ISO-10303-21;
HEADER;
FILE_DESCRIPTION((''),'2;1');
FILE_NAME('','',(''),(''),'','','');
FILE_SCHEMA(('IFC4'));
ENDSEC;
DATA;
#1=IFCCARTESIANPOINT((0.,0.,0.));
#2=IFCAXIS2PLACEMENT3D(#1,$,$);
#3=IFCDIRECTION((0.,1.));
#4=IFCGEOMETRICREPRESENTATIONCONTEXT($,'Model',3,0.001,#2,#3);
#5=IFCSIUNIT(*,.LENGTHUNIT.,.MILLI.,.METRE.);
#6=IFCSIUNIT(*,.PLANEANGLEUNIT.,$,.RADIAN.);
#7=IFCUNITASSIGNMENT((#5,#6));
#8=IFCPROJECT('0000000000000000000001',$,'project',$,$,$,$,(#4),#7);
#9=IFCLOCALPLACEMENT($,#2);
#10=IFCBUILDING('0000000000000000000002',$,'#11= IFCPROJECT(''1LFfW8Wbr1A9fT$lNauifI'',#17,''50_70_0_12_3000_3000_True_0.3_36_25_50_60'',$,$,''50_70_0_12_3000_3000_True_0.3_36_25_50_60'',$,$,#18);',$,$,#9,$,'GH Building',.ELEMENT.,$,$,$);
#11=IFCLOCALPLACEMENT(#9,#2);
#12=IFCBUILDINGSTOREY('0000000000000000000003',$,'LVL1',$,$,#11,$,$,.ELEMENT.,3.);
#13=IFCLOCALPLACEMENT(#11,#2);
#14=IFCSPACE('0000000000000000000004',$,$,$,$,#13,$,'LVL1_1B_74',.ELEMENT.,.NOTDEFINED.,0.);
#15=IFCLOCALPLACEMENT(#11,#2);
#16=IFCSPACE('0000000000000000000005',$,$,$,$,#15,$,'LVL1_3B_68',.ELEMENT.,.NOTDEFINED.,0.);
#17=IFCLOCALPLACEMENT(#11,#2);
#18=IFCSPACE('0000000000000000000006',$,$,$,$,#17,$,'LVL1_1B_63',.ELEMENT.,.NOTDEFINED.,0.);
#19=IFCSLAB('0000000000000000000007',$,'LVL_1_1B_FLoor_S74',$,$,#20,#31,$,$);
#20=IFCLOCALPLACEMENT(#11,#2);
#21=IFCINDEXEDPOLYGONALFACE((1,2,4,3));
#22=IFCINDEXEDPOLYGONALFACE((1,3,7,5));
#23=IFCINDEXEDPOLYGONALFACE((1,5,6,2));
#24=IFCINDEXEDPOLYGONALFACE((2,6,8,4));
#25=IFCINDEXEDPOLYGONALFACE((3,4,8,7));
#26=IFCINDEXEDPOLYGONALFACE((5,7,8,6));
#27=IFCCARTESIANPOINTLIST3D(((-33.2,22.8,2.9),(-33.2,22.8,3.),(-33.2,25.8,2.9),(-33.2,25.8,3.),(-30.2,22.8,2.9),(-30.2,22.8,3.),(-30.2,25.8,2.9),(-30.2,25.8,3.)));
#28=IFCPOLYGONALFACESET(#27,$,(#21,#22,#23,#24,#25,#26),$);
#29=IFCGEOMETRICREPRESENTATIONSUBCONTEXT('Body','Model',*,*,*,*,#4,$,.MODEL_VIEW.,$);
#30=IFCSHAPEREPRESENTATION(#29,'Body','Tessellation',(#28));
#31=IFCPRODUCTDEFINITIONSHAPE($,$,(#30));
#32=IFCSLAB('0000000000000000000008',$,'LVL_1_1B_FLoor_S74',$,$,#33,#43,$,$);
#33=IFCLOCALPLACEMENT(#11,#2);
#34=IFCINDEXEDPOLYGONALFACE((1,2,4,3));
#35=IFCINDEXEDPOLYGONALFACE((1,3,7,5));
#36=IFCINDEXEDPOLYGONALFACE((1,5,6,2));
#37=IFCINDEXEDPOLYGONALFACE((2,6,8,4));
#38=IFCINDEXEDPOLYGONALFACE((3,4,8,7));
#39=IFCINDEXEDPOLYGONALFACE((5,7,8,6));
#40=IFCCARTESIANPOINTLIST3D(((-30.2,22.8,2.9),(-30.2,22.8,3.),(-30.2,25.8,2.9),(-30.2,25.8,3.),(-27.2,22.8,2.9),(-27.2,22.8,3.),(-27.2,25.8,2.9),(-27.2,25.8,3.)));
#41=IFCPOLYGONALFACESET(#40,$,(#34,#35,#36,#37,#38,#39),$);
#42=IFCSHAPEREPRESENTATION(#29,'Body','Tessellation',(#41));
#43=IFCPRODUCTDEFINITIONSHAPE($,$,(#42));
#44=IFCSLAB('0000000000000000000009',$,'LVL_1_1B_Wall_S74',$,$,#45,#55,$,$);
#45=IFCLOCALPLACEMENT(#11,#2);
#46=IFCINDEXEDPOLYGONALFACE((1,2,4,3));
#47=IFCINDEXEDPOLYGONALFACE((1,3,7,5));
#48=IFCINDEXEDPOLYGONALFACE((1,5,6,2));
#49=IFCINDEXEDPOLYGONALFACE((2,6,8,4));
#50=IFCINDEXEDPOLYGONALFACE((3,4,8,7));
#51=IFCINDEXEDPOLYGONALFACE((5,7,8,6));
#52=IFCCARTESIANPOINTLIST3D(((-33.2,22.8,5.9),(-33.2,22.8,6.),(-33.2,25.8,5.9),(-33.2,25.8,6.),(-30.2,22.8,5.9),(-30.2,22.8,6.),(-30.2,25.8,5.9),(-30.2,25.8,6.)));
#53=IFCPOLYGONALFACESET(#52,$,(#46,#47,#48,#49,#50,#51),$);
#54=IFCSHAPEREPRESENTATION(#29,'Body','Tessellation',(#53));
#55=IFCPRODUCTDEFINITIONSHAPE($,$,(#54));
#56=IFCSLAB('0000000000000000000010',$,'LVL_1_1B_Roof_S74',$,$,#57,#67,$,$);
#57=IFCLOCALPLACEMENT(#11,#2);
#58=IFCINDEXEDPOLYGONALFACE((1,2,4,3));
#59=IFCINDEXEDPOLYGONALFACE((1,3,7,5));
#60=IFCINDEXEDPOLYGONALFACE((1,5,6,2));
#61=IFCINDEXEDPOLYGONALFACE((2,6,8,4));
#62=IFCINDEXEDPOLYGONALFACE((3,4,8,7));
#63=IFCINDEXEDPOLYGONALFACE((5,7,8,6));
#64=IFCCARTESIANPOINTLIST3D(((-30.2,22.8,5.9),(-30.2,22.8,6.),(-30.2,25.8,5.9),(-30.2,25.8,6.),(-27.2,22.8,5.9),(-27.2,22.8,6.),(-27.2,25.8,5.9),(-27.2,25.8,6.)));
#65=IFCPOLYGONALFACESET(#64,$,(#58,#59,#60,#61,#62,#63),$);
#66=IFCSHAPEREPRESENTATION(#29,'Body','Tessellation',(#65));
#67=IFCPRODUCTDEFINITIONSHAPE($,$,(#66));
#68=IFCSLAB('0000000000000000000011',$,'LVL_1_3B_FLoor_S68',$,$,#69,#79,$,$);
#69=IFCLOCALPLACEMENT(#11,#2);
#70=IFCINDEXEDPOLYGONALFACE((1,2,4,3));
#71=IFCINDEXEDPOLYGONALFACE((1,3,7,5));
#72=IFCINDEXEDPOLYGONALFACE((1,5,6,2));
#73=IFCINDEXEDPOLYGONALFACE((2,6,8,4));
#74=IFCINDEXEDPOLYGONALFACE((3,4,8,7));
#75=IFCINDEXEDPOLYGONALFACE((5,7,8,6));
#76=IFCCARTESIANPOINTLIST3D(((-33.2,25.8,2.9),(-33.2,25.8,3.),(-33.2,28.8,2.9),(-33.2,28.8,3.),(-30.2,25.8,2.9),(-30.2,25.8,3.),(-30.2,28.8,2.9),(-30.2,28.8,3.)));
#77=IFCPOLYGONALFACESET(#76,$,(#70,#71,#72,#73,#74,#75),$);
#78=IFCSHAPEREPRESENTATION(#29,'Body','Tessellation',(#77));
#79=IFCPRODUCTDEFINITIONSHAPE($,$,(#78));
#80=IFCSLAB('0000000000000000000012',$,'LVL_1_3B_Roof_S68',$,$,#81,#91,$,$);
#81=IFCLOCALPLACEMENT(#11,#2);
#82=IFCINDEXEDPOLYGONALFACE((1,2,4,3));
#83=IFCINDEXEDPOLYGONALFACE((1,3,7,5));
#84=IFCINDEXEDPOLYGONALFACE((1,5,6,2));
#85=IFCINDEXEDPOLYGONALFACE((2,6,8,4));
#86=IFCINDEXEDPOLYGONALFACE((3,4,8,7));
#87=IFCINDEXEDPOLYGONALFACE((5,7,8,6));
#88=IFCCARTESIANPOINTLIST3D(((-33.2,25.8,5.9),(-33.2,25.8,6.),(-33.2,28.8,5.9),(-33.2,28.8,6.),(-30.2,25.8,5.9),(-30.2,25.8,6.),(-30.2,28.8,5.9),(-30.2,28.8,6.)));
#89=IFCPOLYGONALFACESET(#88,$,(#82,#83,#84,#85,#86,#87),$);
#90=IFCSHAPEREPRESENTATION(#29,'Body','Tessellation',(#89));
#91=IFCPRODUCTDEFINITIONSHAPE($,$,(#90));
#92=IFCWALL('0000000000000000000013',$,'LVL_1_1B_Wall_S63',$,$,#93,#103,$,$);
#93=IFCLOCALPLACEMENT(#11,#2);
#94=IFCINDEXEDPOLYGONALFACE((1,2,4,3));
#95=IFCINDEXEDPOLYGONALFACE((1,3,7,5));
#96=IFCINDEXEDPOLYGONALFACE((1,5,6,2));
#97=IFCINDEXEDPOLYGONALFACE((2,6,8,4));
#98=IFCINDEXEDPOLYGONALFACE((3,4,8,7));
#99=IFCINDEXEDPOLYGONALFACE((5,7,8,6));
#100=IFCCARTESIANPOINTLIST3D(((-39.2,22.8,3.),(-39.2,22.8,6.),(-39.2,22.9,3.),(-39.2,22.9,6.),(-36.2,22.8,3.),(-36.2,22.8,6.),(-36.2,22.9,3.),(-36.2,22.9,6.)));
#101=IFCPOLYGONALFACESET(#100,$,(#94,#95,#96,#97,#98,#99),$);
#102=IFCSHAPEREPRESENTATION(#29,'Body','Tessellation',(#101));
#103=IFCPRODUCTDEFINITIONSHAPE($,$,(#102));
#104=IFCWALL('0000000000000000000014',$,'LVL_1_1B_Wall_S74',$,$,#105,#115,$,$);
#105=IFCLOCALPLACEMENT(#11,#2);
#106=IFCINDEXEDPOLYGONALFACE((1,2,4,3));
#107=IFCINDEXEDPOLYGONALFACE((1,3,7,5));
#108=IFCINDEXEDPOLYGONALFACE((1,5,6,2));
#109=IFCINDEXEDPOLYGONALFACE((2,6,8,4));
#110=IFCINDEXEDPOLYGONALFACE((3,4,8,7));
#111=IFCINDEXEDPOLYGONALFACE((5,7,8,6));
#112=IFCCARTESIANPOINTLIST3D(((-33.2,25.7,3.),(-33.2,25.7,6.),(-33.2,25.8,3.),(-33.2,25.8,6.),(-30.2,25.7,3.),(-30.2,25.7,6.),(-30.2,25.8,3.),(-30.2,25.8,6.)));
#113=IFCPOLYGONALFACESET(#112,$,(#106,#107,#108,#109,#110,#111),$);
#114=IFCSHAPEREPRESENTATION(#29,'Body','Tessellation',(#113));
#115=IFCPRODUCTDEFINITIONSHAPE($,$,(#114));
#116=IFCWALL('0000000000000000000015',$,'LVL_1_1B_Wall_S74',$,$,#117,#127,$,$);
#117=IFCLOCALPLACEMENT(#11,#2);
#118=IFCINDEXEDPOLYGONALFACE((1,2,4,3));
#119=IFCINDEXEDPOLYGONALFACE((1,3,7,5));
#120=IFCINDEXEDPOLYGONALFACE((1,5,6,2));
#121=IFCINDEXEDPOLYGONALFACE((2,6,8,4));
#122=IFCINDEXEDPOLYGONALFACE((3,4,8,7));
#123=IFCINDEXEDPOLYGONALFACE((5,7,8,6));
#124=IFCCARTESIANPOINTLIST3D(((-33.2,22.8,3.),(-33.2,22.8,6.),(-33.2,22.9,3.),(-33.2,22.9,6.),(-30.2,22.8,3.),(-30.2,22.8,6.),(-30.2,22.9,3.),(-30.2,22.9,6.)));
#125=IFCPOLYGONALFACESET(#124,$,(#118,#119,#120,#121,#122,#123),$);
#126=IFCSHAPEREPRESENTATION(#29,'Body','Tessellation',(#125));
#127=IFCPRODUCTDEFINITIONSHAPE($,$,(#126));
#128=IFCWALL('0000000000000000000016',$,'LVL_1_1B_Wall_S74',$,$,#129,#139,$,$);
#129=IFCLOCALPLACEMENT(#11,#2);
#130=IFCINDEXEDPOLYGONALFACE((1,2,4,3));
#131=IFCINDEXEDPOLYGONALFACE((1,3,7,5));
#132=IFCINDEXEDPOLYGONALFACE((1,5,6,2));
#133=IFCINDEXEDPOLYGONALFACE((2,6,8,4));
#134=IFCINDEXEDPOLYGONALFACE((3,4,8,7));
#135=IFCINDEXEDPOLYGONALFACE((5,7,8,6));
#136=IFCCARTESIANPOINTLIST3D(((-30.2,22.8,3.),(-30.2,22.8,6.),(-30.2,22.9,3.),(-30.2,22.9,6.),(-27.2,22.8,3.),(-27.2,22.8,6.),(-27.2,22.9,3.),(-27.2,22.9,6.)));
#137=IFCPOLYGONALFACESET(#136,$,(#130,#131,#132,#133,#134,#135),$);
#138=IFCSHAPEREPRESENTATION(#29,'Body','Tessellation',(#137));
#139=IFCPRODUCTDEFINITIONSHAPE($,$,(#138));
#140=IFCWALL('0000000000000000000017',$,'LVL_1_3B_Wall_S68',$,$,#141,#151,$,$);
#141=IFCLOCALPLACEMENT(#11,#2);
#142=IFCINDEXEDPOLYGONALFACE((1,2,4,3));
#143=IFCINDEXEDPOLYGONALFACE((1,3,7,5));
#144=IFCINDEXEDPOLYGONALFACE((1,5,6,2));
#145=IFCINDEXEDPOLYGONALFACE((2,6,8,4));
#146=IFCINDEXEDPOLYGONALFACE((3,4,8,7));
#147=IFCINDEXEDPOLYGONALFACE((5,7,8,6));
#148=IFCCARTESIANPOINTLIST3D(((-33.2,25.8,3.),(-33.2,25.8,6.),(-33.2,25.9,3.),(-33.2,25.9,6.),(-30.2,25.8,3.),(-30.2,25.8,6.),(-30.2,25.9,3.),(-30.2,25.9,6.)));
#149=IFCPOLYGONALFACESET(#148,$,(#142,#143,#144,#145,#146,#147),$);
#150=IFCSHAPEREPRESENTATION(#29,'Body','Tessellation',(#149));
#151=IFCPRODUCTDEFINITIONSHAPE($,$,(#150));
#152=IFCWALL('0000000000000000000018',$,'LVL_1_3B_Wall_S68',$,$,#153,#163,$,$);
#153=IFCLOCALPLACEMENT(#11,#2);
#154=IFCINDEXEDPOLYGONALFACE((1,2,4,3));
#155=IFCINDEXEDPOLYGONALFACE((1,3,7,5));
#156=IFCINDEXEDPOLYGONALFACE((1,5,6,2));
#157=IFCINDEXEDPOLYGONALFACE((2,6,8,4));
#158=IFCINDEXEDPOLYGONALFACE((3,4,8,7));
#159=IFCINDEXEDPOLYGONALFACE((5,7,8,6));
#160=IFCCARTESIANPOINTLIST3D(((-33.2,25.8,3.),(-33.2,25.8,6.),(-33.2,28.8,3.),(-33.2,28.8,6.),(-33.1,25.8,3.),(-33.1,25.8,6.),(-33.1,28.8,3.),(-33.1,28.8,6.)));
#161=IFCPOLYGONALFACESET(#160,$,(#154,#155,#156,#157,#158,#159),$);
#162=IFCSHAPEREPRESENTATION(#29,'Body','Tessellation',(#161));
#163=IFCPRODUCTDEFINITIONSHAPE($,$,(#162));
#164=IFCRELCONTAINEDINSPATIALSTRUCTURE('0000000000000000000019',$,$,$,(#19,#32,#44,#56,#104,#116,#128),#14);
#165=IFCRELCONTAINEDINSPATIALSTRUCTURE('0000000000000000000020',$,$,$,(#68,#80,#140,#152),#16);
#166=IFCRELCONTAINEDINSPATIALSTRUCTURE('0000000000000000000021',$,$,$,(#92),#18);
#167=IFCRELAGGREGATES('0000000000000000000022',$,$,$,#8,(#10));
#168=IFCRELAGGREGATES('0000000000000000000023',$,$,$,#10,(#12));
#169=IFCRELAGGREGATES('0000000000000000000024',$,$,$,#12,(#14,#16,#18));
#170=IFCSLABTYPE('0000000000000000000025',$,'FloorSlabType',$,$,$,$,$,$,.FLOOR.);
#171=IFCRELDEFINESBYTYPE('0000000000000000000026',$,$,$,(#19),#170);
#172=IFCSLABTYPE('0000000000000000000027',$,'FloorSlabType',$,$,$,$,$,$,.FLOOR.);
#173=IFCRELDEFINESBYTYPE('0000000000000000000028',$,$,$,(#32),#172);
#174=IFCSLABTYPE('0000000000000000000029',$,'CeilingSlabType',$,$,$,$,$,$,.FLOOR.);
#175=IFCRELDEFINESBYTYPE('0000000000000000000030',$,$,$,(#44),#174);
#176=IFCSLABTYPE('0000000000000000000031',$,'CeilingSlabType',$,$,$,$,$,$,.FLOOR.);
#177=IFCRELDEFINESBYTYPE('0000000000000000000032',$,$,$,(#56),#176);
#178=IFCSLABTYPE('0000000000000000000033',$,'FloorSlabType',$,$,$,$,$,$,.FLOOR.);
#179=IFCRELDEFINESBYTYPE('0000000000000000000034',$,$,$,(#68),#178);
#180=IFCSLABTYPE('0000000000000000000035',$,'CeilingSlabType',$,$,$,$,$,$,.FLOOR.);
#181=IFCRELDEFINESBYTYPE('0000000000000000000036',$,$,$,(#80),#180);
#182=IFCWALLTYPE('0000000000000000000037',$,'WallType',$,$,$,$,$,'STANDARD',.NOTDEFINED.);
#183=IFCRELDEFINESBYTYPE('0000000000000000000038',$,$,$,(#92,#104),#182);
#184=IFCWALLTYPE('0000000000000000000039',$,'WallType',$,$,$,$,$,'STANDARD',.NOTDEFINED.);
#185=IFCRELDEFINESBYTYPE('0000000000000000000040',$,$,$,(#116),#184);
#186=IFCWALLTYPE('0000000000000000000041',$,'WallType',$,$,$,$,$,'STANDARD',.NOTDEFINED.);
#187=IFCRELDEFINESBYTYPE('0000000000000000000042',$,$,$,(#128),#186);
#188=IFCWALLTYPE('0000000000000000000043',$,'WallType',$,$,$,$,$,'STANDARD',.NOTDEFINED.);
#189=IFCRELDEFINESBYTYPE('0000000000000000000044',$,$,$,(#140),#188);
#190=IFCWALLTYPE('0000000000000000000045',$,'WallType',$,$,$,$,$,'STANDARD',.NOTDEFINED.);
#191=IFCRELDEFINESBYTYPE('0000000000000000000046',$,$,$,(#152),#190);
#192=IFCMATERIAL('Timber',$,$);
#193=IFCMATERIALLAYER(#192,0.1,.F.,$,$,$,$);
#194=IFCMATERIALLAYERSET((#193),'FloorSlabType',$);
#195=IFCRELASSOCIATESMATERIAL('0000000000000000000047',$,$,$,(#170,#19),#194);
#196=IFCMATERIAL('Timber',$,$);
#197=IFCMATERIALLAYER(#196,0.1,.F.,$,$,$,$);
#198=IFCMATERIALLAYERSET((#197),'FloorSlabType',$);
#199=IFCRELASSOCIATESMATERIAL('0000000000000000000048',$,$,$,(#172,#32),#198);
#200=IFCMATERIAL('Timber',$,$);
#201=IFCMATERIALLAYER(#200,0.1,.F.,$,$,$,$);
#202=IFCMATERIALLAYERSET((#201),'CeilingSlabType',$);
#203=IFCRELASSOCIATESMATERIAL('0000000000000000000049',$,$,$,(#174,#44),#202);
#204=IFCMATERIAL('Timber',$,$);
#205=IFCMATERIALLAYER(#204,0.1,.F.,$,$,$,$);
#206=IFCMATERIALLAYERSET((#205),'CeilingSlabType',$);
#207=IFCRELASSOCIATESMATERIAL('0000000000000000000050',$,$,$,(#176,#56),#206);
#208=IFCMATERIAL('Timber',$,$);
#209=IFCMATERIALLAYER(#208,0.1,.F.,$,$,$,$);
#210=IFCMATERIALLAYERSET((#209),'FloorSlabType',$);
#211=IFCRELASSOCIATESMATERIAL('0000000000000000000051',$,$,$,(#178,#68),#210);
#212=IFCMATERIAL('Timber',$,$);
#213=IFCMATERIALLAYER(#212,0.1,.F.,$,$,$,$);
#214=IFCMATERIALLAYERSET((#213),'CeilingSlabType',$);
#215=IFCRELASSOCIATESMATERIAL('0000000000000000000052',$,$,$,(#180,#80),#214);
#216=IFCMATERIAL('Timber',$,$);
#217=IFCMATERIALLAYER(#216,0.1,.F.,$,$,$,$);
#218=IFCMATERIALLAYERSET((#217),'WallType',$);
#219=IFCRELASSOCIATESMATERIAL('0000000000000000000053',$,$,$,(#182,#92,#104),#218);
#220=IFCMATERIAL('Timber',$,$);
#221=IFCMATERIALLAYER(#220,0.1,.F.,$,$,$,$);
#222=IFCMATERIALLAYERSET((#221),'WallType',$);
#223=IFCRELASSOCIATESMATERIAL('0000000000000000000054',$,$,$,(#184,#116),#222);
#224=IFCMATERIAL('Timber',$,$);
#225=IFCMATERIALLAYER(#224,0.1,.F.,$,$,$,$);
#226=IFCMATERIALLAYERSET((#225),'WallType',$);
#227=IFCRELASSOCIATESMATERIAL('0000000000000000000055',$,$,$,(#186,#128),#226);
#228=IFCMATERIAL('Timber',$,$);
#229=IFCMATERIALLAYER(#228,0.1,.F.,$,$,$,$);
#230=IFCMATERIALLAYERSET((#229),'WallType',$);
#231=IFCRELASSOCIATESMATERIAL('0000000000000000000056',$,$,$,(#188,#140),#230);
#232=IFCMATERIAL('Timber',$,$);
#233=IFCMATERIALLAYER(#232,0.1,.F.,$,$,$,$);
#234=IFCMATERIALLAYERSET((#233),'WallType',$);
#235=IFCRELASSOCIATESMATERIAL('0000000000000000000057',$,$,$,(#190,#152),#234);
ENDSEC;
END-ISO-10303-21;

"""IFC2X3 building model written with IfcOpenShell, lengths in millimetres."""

from ifc_helpers import new_model, si_unit, direction, frame, frame_2d, origin, place, context, subcontext, project, spatial, rectangle, extrude, material, layer, layer_set, layer_usage, type_object, element, save


model = new_model("IFC2X3")

# Units and contexts
model_context = context("Model", 3, precision=0.001, world=origin(), true_north=direction((0.0, 1.0)))
body_context = subcontext(model_context, "Body", "Model", "MODEL_VIEW")
ifc_project = project(units=[si_unit("LENGTHUNIT", "METRE", prefix="MILLI"), si_unit("PLANEANGLEUNIT", "RADIAN")], contexts=[model_context])

# Building, storey
building_placement = place(None, origin())
building = spatial("IfcBuilding", under=ifc_project, at=building_placement, Name="#11= IFCPROJECT('1LFfW8Wbr1A9fT$lNauifI',#17,'50_70_0_12_3000_3000_True_0.3_36_25_50_60',$,$,'50_70_0_12_3000_3000_True_0.3_36_25_50_60',$,$,#18);", LongName="GH Building", CompositionType="ELEMENT")
storey_placement = place(building_placement, origin())
storey = spatial("IfcBuildingStorey", under=building, at=storey_placement, Name="LVL1", CompositionType="ELEMENT", Elevation=3.0)

# Shared definitions
space_1_placement = place(storey_placement, origin())
space_1 = spatial("IfcSpace", under=storey, at=space_1_placement, LongName="LVL1_1B_74", CompositionType="ELEMENT", InteriorOrExteriorSpace="NOTDEFINED", ElevationWithFlooring=0.0)

# Slabs
ifc_material_1 = material(Name="Timber")
ifc_layer_1 = layer(ifc_material_1, 0.1, ventilated=False)
ifc_layer_set_1 = layer_set([ifc_layer_1], Name="FloorSlabType")
ifc_layer_usage_1 = layer_usage(ifc_layer_set_1, "AXIS3", "NEGATIVE", -0.1)
slab_type_1 = type_object("IfcSlabType", Name="FloorSlabType", PredefinedType="FLOOR", material=ifc_layer_set_1)
slab_1_placement = place(space_1_placement, frame((-33.2, 22.8, 2.9)))
element("IfcSlab", 1, at=slab_1_placement, inside=space_1, type_object=slab_type_1, material=ifc_layer_usage_1, Name="LVL_1_1B_FLoor_S74", context=body_context, shape_type="SweptSolid", body=[
    extrude(rectangle(XDim=3.0, YDim=3.0, at=frame_2d((1.5, 1.5))), origin(), (0.0, 0.0, 1.0), 0.1),
])
ifc_material_2 = material(Name="Timber")
ifc_layer_2 = layer(ifc_material_2, 0.1, ventilated=False)
ifc_layer_set_2 = layer_set([ifc_layer_2], Name="FloorSlabType")
ifc_layer_usage_2 = layer_usage(ifc_layer_set_2, "AXIS3", "NEGATIVE", -0.1)
slab_type_2 = type_object("IfcSlabType", Name="FloorSlabType", PredefinedType="FLOOR", material=ifc_layer_set_2)
slab_2_placement = place(space_1_placement, frame((-30.2, 22.8, 2.9)))
element("IfcSlab", 2, at=slab_2_placement, inside=space_1, type_object=slab_type_2, material=ifc_layer_usage_2, Name="LVL_1_1B_FLoor_S74", context=body_context, shape_type="SweptSolid", body=[
    extrude(rectangle(XDim=3.0, YDim=3.0, at=frame_2d((1.5, 1.5))), origin(), (0.0, 0.0, 1.0), 0.1),
])
ifc_material_3 = material(Name="Timber")
ifc_layer_3 = layer(ifc_material_3, 0.1, ventilated=False)
ifc_layer_set_3 = layer_set([ifc_layer_3], Name="CeilingSlabType")
ifc_layer_usage_3 = layer_usage(ifc_layer_set_3, "AXIS3", "NEGATIVE", -0.1)
slab_type_3 = type_object("IfcSlabType", Name="CeilingSlabType", PredefinedType="FLOOR", material=ifc_layer_set_3)
slab_3_placement = place(space_1_placement, frame((-33.2, 22.8, 5.9)))
element("IfcSlab", 3, at=slab_3_placement, inside=space_1, type_object=slab_type_3, material=ifc_layer_usage_3, Name="LVL_1_1B_Wall_S74", context=body_context, shape_type="SweptSolid", body=[
    extrude(rectangle(XDim=3.0, YDim=3.0, at=frame_2d((1.5, 1.5))), origin(), (0.0, 0.0, 1.0), 0.1),
])
ifc_material_4 = material(Name="Timber")
ifc_layer_4 = layer(ifc_material_4, 0.1, ventilated=False)
ifc_layer_set_4 = layer_set([ifc_layer_4], Name="CeilingSlabType")
ifc_layer_usage_4 = layer_usage(ifc_layer_set_4, "AXIS3", "NEGATIVE", -0.1)
slab_type_4 = type_object("IfcSlabType", Name="CeilingSlabType", PredefinedType="FLOOR", material=ifc_layer_set_4)
slab_4_placement = place(space_1_placement, frame((-30.2, 22.8, 5.9)))
element("IfcSlab", 4, at=slab_4_placement, inside=space_1, type_object=slab_type_4, material=ifc_layer_usage_4, Name="LVL_1_1B_Roof_S74", context=body_context, shape_type="SweptSolid", body=[
    extrude(rectangle(XDim=3.0, YDim=3.0, at=frame_2d((1.5, 1.5))), origin(), (0.0, 0.0, 1.0), 0.1),
])

# Shared definitions
space_2_placement = place(storey_placement, origin())
space_2 = spatial("IfcSpace", under=storey, at=space_2_placement, LongName="LVL1_3B_68", CompositionType="ELEMENT", InteriorOrExteriorSpace="NOTDEFINED", ElevationWithFlooring=0.0)

# Slabs
ifc_material_5 = material(Name="Timber")
ifc_layer_5 = layer(ifc_material_5, 0.1, ventilated=False)
ifc_layer_set_5 = layer_set([ifc_layer_5], Name="FloorSlabType")
ifc_layer_usage_5 = layer_usage(ifc_layer_set_5, "AXIS3", "NEGATIVE", -0.1)
slab_type_5 = type_object("IfcSlabType", Name="FloorSlabType", PredefinedType="FLOOR", material=ifc_layer_set_5)
slab_5_placement = place(space_2_placement, frame((-30.2, 25.8, 2.9), z_axis=(0.0, 0.0, 1.0), x_axis=(0.0, 1.0, 0.0)))
element("IfcSlab", 5, at=slab_5_placement, inside=space_2, type_object=slab_type_5, material=ifc_layer_usage_5, Name="LVL_1_3B_FLoor_S68", context=body_context, shape_type="SweptSolid", body=[
    extrude(rectangle(XDim=3.0, YDim=3.0, at=frame_2d((1.5, 1.5))), origin(), (0.0, 0.0, 1.0), 0.1),
])
ifc_material_6 = material(Name="Timber")
ifc_layer_6 = layer(ifc_material_6, 0.1, ventilated=False)
ifc_layer_set_6 = layer_set([ifc_layer_6], Name="CeilingSlabType")
ifc_layer_usage_6 = layer_usage(ifc_layer_set_6, "AXIS3", "NEGATIVE", -0.1)
slab_type_6 = type_object("IfcSlabType", Name="CeilingSlabType", PredefinedType="FLOOR", material=ifc_layer_set_6)
slab_6_placement = place(space_2_placement, frame((-30.2, 25.8, 5.9), z_axis=(0.0, 0.0, 1.0), x_axis=(0.0, 1.0, 0.0)))
element("IfcSlab", 6, at=slab_6_placement, inside=space_2, type_object=slab_type_6, material=ifc_layer_usage_6, Name="LVL_1_3B_Roof_S68", context=body_context, shape_type="SweptSolid", body=[
    extrude(rectangle(XDim=3.0, YDim=3.0, at=frame_2d((1.5, 1.5))), origin(), (0.0, 0.0, 1.0), 0.1),
])

# Shared definitions
space_3_placement = place(storey_placement, origin())
space_3 = spatial("IfcSpace", under=storey, at=space_3_placement, LongName="LVL1_1B_63", CompositionType="ELEMENT", InteriorOrExteriorSpace="NOTDEFINED", ElevationWithFlooring=0.0)

# Walls
ifc_material_7 = material(Name="Timber")
ifc_layer_7 = layer(ifc_material_7, 0.1, ventilated=False)
ifc_layer_set_7 = layer_set([ifc_layer_7], Name="WallType")
ifc_layer_usage_7 = layer_usage(ifc_layer_set_7, "AXIS2", "NEGATIVE", 0.0)
wall_type_1 = type_object("IfcWallType", Name="WallType", ElementType="STANDARD", PredefinedType="NOTDEFINED", material=ifc_layer_set_7)
wall_1_placement = place(space_3_placement, frame((-36.2, 22.8, 3.0), z_axis=(0.0, 0.0, 1.0), x_axis=(-1.0, 0.0, 0.0)))
element("IfcWall", 7, at=wall_1_placement, inside=space_3, type_object=wall_type_1, material=ifc_layer_usage_7, Name="LVL_1_1B_Wall_S63", context=body_context, shape_type="SweptSolid", body=[
    extrude(rectangle(XDim=3.0, YDim=0.1, at=frame_2d((1.5, -0.1))), origin(), (0.0, 0.0, 1.0), 3.0),
])
ifc_layer_usage_8 = layer_usage(ifc_layer_set_7, "AXIS2", "NEGATIVE", 0.0)
wall_2_placement = place(space_1_placement, frame((-33.2, 25.8, 3.0)))
element("IfcWall", 8, at=wall_2_placement, inside=space_1, type_object=wall_type_1, material=ifc_layer_usage_8, Name="LVL_1_1B_Wall_S74", context=body_context, shape_type="SweptSolid", body=[
    extrude(rectangle(XDim=3.0, YDim=0.1, at=frame_2d((1.5, -0.1))), origin(), (0.0, 0.0, 1.0), 3.0),
])
ifc_material_8 = material(Name="Timber")
ifc_layer_8 = layer(ifc_material_8, 0.1, ventilated=False)
ifc_layer_set_8 = layer_set([ifc_layer_8], Name="WallType")
ifc_layer_usage_9 = layer_usage(ifc_layer_set_8, "AXIS2", "NEGATIVE", 0.0)
wall_type_2 = type_object("IfcWallType", Name="WallType", ElementType="STANDARD", PredefinedType="NOTDEFINED", material=ifc_layer_set_8)
wall_3_placement = place(space_1_placement, frame((-30.2, 22.8, 3.0), z_axis=(0.0, 0.0, 1.0), x_axis=(-1.0, 0.0, 0.0)))
element("IfcWall", 9, at=wall_3_placement, inside=space_1, type_object=wall_type_2, material=ifc_layer_usage_9, Name="LVL_1_1B_Wall_S74", context=body_context, shape_type="SweptSolid", body=[
    extrude(rectangle(XDim=3.0, YDim=0.1, at=frame_2d((1.5, -0.1))), origin(), (0.0, 0.0, 1.0), 3.0),
])
ifc_material_9 = material(Name="Timber")
ifc_layer_9 = layer(ifc_material_9, 0.1, ventilated=False)
ifc_layer_set_9 = layer_set([ifc_layer_9], Name="WallType")
ifc_layer_usage_10 = layer_usage(ifc_layer_set_9, "AXIS2", "NEGATIVE", 0.0)
wall_type_3 = type_object("IfcWallType", Name="WallType", ElementType="STANDARD", PredefinedType="NOTDEFINED", material=ifc_layer_set_9)
wall_4_placement = place(space_1_placement, frame((-27.2, 22.8, 3.0), z_axis=(0.0, 0.0, 1.0), x_axis=(-1.0, 0.0, 0.0)))
element("IfcWall", 10, at=wall_4_placement, inside=space_1, type_object=wall_type_3, material=ifc_layer_usage_10, Name="LVL_1_1B_Wall_S74", context=body_context, shape_type="SweptSolid", body=[
    extrude(rectangle(XDim=3.0, YDim=0.1, at=frame_2d((1.5, -0.1))), origin(), (0.0, 0.0, 1.0), 3.0),
])

# Walls
ifc_material_10 = material(Name="Timber")
ifc_layer_10 = layer(ifc_material_10, 0.1, ventilated=False)
ifc_layer_set_10 = layer_set([ifc_layer_10], Name="WallType")
ifc_layer_usage_11 = layer_usage(ifc_layer_set_10, "AXIS2", "NEGATIVE", 0.0)
wall_type_4 = type_object("IfcWallType", Name="WallType", ElementType="STANDARD", PredefinedType="NOTDEFINED", material=ifc_layer_set_10)
wall_5_placement = place(space_2_placement, frame((-30.2, 25.8, 3.0), z_axis=(0.0, 0.0, 1.0), x_axis=(-1.0, 0.0, 0.0)))
element("IfcWall", 11, at=wall_5_placement, inside=space_2, type_object=wall_type_4, material=ifc_layer_usage_11, Name="LVL_1_3B_Wall_S68", context=body_context, shape_type="SweptSolid", body=[
    extrude(rectangle(XDim=3.0, YDim=0.1, at=frame_2d((1.5, -0.1))), origin(), (0.0, 0.0, 1.0), 3.0),
])
ifc_material_11 = material(Name="Timber")
ifc_layer_11 = layer(ifc_material_11, 0.1, ventilated=False)
ifc_layer_set_11 = layer_set([ifc_layer_11], Name="WallType")
ifc_layer_usage_12 = layer_usage(ifc_layer_set_11, "AXIS2", "NEGATIVE", 0.0)
wall_type_5 = type_object("IfcWallType", Name="WallType", ElementType="STANDARD", PredefinedType="NOTDEFINED", material=ifc_layer_set_11)
wall_6_placement = place(space_2_placement, frame((-33.2, 25.8, 3.0), z_axis=(0.0, 0.0, 1.0), x_axis=(0.0, 1.0, 0.0)))
element("IfcWall", 12, at=wall_6_placement, inside=space_2, type_object=wall_type_5, material=ifc_layer_usage_12, Name="LVL_1_3B_Wall_S68", context=body_context, shape_type="SweptSolid", body=[
    extrude(rectangle(XDim=3.0, YDim=0.1, at=frame_2d((1.5, -0.1))), origin(), (0.0, 0.0, 1.0), 3.0),
])

save(model, "model.ifc")
